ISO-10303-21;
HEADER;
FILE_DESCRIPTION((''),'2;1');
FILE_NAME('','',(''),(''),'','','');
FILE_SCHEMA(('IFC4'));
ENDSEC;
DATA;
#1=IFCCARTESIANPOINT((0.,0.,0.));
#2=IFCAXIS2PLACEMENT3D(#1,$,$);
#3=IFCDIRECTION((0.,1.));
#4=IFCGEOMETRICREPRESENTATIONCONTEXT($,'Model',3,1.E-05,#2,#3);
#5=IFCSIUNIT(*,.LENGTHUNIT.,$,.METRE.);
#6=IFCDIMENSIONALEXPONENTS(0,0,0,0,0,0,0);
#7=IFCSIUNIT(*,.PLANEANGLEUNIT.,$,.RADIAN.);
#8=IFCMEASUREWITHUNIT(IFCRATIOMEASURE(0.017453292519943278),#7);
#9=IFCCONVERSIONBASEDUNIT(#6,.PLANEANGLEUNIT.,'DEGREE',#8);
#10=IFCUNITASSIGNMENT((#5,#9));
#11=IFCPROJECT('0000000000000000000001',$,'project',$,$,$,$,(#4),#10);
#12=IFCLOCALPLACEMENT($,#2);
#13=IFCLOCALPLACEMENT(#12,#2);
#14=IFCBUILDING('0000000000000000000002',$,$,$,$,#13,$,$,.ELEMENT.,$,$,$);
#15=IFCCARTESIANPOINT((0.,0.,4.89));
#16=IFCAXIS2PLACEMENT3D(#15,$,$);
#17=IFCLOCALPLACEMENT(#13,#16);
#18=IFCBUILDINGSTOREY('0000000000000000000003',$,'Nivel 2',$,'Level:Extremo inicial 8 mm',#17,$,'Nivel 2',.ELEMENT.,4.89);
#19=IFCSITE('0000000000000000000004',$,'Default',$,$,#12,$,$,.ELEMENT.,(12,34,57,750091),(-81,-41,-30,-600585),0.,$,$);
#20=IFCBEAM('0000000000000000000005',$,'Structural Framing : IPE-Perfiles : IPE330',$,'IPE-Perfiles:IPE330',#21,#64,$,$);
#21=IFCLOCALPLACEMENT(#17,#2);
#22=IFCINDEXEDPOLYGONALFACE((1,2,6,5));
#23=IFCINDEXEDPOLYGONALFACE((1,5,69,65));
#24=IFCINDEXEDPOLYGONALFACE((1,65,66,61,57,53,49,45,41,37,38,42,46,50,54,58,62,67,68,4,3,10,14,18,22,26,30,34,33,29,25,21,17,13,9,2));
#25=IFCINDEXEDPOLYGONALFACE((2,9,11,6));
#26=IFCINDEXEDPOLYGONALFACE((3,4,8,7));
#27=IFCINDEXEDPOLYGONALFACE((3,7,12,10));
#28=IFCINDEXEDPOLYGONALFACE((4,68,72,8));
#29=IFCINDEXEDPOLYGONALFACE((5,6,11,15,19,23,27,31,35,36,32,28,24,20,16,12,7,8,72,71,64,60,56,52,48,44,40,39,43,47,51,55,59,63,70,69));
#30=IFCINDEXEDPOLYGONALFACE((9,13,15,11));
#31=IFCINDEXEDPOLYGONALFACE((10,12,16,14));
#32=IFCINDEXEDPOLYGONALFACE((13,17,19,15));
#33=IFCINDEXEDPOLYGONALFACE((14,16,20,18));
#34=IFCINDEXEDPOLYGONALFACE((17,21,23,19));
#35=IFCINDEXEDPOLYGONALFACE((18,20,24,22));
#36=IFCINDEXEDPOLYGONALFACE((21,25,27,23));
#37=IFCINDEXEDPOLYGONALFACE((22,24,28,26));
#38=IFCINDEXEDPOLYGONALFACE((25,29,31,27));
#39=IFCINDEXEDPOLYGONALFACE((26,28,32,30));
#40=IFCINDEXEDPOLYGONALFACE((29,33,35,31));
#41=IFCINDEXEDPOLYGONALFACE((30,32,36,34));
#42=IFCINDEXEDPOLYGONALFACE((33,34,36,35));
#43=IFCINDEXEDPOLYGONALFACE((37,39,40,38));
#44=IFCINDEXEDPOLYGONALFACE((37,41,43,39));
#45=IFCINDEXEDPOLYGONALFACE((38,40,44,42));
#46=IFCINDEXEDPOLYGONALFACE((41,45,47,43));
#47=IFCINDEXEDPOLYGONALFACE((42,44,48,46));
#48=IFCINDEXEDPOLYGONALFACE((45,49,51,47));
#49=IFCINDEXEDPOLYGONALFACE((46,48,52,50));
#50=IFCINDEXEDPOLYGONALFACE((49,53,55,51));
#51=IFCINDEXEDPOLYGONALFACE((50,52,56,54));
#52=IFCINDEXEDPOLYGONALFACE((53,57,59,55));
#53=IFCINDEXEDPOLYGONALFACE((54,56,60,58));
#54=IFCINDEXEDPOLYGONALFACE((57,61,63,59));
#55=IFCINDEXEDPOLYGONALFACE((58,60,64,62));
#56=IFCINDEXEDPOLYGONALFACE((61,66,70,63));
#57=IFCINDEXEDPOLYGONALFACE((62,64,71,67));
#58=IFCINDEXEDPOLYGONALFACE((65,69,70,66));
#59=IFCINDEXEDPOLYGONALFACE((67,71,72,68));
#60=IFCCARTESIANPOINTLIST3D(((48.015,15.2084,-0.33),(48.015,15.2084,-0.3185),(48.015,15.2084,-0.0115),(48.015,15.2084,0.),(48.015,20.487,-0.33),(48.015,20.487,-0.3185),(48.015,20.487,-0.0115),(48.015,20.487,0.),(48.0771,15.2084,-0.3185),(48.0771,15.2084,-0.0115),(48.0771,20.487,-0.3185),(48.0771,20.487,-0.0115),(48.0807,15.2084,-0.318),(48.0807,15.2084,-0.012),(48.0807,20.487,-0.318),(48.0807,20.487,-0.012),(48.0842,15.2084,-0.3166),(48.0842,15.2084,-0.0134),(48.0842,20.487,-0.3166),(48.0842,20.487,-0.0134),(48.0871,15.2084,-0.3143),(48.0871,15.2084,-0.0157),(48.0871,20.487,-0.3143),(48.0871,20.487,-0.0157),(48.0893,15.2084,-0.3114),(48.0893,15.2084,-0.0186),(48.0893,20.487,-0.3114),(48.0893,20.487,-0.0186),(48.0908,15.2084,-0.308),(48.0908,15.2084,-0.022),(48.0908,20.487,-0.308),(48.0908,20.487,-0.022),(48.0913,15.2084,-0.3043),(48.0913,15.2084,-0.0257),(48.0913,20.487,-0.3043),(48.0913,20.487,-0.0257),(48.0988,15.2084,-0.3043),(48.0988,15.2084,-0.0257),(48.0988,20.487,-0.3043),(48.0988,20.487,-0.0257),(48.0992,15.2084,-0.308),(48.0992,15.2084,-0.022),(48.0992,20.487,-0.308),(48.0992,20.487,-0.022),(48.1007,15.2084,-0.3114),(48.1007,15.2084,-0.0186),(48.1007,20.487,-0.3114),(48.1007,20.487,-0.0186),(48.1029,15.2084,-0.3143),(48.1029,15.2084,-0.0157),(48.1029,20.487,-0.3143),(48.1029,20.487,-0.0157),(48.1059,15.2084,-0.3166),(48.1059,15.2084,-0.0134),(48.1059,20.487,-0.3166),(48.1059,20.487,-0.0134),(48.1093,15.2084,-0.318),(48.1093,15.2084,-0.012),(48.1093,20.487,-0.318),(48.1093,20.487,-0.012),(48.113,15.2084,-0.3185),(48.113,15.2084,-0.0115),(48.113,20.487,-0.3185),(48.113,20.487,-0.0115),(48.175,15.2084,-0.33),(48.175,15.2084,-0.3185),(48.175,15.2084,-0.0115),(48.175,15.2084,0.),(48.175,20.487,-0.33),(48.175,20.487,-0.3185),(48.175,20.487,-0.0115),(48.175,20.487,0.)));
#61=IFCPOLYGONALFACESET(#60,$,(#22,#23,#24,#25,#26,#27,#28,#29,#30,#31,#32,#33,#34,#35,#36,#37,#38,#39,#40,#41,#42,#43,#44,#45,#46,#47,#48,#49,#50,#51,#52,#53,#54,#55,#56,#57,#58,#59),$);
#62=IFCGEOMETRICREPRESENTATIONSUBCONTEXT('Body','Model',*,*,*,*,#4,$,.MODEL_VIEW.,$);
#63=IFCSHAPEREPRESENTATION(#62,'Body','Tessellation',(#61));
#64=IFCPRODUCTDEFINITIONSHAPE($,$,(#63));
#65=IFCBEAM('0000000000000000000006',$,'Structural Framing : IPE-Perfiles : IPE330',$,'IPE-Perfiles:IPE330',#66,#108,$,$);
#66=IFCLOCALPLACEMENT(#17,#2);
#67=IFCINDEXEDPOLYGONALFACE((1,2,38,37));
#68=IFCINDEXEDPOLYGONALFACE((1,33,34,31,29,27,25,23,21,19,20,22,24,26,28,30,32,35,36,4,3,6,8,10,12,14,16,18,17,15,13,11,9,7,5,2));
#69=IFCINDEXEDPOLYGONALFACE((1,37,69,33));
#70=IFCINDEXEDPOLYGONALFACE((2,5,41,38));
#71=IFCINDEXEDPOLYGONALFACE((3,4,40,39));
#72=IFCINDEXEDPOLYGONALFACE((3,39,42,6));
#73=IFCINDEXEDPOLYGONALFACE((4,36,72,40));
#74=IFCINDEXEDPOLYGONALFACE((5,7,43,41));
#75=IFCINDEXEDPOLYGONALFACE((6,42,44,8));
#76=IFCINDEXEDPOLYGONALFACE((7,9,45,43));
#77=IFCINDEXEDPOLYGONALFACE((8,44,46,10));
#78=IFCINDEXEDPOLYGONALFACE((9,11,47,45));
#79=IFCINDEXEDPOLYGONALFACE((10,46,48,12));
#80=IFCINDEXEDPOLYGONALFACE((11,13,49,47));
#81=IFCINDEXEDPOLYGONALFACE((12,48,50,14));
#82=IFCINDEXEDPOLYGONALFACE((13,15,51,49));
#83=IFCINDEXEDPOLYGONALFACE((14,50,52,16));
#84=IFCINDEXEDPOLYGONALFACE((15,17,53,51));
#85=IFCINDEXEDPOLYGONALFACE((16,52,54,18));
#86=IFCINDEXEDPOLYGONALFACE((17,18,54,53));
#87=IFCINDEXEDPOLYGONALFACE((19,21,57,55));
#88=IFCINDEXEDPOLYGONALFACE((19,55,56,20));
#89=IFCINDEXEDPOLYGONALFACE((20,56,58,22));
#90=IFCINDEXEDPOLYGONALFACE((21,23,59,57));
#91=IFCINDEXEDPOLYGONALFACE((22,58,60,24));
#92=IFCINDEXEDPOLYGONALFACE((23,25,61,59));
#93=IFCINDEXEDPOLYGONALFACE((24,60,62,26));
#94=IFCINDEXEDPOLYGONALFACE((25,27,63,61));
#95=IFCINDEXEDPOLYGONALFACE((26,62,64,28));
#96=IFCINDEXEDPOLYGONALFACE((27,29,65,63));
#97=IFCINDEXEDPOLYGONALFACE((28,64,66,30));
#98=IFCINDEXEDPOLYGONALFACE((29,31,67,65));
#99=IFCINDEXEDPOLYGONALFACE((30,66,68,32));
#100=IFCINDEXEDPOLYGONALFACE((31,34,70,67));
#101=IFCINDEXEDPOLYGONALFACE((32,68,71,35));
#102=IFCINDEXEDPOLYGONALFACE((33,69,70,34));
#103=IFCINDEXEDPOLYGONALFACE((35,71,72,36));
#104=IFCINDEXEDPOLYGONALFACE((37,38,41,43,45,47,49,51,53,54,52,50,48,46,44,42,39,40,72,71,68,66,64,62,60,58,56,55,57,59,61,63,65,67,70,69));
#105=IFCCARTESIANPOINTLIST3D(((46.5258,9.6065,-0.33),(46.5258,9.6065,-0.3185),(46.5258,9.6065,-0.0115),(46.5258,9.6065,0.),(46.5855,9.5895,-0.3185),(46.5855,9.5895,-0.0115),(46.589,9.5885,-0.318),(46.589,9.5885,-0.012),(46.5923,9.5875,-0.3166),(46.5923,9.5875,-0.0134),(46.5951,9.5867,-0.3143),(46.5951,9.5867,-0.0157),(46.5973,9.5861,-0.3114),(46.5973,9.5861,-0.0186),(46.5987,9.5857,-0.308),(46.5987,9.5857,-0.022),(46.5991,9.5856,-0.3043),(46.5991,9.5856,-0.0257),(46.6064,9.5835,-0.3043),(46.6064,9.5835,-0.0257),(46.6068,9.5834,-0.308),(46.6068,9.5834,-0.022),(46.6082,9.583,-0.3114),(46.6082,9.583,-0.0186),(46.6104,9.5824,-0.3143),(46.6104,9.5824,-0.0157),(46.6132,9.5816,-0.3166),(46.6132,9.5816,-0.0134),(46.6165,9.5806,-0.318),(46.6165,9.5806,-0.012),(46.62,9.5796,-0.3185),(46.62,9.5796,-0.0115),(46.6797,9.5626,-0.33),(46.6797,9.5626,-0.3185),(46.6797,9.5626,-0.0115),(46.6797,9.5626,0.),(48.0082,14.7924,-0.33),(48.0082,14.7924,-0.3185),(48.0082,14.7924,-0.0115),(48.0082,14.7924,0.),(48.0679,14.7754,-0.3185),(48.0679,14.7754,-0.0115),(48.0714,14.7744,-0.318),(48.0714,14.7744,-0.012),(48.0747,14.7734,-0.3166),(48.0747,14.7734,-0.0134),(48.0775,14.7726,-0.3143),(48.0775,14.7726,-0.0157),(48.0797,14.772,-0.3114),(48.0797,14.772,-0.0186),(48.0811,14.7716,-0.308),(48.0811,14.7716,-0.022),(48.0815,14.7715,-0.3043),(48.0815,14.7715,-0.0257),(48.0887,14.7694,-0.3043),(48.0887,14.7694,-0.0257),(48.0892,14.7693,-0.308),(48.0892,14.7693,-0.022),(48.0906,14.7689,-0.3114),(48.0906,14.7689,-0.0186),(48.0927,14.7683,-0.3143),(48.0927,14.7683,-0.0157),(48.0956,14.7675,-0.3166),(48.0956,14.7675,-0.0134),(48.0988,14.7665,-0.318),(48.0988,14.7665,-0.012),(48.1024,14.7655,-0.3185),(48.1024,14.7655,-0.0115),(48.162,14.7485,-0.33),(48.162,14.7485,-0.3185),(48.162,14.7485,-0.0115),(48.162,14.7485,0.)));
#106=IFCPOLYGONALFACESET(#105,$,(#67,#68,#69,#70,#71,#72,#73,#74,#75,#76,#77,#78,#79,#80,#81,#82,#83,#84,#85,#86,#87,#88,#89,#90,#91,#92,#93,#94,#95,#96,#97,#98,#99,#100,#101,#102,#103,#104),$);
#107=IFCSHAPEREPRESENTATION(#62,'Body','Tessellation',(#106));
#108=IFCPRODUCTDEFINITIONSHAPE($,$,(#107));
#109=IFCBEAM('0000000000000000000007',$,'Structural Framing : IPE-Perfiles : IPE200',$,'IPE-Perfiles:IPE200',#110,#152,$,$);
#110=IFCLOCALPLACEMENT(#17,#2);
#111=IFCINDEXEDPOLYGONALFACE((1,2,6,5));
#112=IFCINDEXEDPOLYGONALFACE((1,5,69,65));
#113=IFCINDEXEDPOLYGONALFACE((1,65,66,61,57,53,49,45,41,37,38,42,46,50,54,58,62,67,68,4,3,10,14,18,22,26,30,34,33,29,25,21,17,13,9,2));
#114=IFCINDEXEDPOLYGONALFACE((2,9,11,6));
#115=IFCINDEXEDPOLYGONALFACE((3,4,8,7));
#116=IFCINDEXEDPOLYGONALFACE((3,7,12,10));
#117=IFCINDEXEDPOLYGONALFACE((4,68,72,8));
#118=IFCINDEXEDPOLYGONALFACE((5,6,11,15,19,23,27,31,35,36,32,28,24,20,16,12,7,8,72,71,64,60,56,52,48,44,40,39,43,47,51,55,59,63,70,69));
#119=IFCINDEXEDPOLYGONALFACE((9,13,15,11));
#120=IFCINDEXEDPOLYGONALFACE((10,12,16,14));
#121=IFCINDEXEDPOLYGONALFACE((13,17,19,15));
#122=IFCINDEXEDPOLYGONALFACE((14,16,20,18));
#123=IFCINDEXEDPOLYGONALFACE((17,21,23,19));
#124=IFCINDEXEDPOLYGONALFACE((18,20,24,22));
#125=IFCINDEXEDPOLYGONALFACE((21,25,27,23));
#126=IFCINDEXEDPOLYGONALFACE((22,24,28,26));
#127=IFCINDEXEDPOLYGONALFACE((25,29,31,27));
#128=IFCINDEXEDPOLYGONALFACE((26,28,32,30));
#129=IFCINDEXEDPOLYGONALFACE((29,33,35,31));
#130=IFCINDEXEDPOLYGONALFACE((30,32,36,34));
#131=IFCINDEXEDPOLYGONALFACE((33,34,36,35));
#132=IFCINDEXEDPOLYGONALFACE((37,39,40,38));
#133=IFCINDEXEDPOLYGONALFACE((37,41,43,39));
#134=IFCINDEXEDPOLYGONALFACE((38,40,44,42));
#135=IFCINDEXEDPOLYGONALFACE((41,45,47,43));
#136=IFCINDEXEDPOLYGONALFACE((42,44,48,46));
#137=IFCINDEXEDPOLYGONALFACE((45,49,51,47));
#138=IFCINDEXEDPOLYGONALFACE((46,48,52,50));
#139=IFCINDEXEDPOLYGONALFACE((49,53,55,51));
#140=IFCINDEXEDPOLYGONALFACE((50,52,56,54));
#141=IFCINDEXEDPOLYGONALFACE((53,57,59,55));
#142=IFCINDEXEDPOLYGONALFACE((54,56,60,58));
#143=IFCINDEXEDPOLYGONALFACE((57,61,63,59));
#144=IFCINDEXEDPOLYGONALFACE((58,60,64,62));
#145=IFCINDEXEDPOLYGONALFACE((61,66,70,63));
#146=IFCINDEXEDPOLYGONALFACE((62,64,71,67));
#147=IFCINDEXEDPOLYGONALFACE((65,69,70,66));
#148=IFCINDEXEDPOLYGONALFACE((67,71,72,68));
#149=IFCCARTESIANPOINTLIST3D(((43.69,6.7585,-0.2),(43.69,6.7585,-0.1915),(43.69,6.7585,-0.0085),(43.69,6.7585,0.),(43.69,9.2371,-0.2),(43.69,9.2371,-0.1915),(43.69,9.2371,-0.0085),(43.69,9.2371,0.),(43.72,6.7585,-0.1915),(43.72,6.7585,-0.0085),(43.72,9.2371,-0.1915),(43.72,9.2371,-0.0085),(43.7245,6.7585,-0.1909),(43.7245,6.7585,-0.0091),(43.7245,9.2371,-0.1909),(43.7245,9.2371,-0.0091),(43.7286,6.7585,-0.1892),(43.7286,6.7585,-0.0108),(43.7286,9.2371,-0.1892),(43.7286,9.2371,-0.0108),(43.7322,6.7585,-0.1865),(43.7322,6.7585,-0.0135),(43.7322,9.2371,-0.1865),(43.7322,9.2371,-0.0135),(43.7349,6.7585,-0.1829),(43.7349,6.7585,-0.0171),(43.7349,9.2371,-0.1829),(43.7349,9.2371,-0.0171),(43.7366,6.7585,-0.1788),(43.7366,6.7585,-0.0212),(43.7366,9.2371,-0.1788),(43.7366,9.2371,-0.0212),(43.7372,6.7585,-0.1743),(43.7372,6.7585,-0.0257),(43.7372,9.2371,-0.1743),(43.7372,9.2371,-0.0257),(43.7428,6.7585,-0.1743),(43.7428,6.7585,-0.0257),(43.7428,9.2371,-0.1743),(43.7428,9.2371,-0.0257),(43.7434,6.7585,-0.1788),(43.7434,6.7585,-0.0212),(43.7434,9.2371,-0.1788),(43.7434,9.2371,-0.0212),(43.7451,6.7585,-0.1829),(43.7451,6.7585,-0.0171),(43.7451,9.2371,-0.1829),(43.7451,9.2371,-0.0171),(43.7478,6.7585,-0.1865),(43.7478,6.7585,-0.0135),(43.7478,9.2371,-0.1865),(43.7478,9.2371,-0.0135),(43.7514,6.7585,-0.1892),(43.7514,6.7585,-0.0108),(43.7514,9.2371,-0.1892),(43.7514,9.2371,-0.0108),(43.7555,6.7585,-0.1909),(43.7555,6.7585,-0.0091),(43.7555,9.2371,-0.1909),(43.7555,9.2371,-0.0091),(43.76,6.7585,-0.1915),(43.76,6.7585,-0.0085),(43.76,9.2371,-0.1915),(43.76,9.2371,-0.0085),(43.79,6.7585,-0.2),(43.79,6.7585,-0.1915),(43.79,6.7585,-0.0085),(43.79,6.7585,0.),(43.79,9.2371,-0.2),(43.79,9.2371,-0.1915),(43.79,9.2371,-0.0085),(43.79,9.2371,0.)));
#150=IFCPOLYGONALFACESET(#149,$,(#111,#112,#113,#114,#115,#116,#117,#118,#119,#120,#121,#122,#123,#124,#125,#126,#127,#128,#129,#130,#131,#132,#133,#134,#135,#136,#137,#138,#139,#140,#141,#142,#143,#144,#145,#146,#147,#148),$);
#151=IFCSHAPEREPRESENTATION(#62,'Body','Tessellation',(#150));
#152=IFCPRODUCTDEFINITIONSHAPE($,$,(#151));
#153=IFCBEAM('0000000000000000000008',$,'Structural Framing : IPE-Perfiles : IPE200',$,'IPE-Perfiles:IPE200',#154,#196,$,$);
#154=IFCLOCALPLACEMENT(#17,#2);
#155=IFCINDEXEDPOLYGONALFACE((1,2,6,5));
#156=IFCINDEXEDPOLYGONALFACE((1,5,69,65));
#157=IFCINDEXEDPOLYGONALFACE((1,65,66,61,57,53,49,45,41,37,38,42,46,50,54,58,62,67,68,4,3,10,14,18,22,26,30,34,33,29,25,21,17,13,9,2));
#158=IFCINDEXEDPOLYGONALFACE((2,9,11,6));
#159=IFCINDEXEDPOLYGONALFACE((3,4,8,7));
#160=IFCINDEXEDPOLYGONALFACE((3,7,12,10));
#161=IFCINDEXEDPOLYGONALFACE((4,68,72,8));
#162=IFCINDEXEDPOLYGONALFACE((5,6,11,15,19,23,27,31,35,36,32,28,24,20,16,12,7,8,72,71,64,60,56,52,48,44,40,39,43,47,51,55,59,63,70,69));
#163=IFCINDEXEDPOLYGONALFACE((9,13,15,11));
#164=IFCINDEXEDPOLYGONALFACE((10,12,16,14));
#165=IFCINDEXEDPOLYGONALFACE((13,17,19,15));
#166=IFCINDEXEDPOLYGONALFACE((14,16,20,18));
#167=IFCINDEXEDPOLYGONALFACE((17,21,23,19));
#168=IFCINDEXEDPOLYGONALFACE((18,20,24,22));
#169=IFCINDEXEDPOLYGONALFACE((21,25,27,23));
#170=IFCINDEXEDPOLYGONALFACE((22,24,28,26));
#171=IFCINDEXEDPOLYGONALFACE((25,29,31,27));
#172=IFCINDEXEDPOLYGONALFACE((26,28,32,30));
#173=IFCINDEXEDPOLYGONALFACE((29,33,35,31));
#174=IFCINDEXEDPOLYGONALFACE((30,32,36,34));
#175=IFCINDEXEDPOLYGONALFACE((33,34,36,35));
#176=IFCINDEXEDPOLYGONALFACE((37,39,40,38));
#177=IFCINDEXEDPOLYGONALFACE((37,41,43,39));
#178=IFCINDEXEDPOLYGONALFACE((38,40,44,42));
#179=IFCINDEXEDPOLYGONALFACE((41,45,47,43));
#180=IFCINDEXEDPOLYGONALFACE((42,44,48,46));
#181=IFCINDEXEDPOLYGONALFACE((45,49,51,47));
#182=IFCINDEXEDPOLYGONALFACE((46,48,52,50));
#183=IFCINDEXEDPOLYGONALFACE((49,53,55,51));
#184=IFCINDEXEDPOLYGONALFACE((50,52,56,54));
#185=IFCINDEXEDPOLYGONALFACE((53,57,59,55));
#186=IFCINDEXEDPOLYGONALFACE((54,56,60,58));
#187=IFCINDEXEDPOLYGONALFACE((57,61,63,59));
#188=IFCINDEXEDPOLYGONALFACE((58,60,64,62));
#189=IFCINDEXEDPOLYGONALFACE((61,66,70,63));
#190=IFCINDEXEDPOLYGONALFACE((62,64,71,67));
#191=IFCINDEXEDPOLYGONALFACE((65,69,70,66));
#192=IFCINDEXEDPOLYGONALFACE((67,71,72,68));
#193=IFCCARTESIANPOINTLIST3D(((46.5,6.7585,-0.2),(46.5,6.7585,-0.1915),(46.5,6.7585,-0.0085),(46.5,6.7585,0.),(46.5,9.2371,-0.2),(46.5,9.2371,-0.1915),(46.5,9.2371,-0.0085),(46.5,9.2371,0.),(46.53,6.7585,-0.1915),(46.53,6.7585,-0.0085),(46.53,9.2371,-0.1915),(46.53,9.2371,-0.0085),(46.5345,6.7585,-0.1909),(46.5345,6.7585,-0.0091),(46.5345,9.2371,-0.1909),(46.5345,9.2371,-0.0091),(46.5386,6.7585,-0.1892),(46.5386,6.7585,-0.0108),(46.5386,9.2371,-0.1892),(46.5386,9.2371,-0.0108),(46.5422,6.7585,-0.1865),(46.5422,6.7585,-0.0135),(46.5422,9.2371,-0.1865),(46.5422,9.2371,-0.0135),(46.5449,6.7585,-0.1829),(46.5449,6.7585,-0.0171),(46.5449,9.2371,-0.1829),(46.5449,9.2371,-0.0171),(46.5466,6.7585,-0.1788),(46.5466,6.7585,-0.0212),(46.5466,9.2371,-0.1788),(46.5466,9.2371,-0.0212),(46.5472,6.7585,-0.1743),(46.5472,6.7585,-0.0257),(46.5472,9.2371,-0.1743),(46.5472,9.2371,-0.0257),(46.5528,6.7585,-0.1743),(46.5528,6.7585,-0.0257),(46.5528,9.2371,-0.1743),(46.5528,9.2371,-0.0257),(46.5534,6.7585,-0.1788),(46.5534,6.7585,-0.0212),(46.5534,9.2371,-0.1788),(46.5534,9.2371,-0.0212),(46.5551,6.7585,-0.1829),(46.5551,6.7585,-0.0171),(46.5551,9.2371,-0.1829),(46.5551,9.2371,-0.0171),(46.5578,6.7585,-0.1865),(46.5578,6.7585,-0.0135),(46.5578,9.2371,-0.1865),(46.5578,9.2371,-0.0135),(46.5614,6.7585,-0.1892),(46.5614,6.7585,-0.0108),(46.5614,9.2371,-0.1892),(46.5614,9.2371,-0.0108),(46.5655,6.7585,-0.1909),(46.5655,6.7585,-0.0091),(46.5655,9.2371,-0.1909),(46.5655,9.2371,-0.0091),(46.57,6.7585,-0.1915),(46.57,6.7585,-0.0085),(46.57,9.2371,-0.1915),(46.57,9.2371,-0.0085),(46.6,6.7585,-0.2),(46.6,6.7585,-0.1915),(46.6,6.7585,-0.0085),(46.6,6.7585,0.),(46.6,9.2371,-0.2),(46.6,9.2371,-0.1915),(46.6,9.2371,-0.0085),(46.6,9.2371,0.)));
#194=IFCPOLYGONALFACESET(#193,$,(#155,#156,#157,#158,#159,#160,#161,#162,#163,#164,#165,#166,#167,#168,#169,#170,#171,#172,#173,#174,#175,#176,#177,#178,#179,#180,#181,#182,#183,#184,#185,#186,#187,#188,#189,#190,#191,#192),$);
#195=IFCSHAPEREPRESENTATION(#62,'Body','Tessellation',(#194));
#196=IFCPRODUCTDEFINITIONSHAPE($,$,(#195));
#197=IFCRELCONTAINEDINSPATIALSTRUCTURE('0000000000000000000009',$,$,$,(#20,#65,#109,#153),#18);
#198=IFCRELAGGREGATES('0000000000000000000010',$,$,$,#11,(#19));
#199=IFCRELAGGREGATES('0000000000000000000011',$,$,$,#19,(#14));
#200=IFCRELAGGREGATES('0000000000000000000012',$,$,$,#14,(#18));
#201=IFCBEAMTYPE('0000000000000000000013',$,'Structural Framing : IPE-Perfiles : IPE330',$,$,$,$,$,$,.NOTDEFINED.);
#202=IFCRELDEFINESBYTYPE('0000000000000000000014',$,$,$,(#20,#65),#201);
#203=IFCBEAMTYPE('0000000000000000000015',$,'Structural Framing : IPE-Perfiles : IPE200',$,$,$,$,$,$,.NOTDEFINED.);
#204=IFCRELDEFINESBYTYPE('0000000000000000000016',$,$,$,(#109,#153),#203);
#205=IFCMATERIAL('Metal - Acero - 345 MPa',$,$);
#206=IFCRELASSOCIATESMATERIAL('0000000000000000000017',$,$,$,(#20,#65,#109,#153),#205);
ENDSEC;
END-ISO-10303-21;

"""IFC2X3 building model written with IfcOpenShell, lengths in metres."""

from ifc_helpers import new_model, entity, si_unit, converted_unit, direction, frame, frame_2d, origin, place, context, subcontext, project, spatial, i_section, extrude, material, type_object, element, save


model = new_model("IFC2X3")

# Units and contexts
model_context = context("Model", 3, precision=1e-05, world=origin(), true_north=direction((0.0, 1.0)))
body_context = subcontext(model_context, "Body", "Model", "MODEL_VIEW")
ifc_project = project(units=[si_unit("LENGTHUNIT", "METRE"), converted_unit("PLANEANGLEUNIT", "DEGREE", entity("IfcRatioMeasure", 0.017453292519943278), si_unit("PLANEANGLEUNIT", "RADIAN"), dimensions=[0, 0, 0, 0, 0, 0, 0])], contexts=[model_context])

# Site, building, storey
site_placement = place(None, origin())
site = spatial("IfcSite", under=ifc_project, at=site_placement, Name="Default", CompositionType="ELEMENT", RefLatitude=(12, 34, 57, 750091), RefLongitude=(-81, -41, -30, -600585), RefElevation=0.0)
building_placement = place(site_placement, origin())
building = spatial("IfcBuilding", under=site, at=building_placement, CompositionType="ELEMENT")
storey_placement = place(building_placement, frame((0.0, 0.0, 4.89)))
storey = spatial("IfcBuildingStorey", under=building, at=storey_placement, Name="Nivel 2", ObjectType="Level:Extremo inicial 8 mm", LongName="Nivel 2", CompositionType="ELEMENT", Elevation=4.89)

# Shared definitions
ifc_material_1 = material(Name="Metal - Acero - 345 MPa")

# Beams
beam_type_1 = type_object("IfcBeamType", Name="Structural Framing : IPE-Perfiles : IPE330", PredefinedType="NOTDEFINED")
beam_1_placement = place(storey_placement, frame((48.095, 15.195, 0.0), z_axis=(0.0, 0.0, 1.0), x_axis=(0.0, 1.0, 0.0)))
element("IfcBeam", 1, at=beam_1_placement, inside=storey, type_object=beam_type_1, material=ifc_material_1, Name="Structural Framing : IPE-Perfiles : IPE330", ObjectType="IPE-Perfiles:IPE330", context=body_context, shape_type="SweptSolid", body=[
    extrude(i_section(OverallWidth=0.16, OverallDepth=0.33, WebThickness=0.0075, FlangeThickness=0.0115, FilletRadius=0.0142, at=frame_2d((0.0, 0.0), x_axis=(0.0, 1.0))), frame((0.0135, 0.0, -0.165), z_axis=(1.0, 0.0, 0.0), x_axis=(0.0, 0.0, -1.0)), (0.0, 0.0, 1.0), 5.2786),
])
beam_2_placement = place(storey_placement, frame((46.55, 9.4, 0.0), z_axis=(0.0, 0.0, 1.0), x_axis=(0.274839, 0.96149, 0.0)))
element("IfcBeam", 2, at=beam_2_placement, inside=storey, type_object=beam_type_1, material=ifc_material_1, Name="Structural Framing : IPE-Perfiles : IPE330", ObjectType="IPE-Perfiles:IPE330", context=body_context, shape_type="SweptSolid", body=[
    extrude(i_section(OverallWidth=0.16, OverallDepth=0.33, WebThickness=0.0075, FlangeThickness=0.0115, FilletRadius=0.0142, at=frame_2d((0.0, 0.0), x_axis=(0.0, 1.0))), frame((0.1919, 0.0, -0.165), z_axis=(1.0, 0.0, 0.0), x_axis=(0.0, 0.0, -1.0)), (0.0, 0.0, 1.0), 5.3936),
])
beam_type_2 = type_object("IfcBeamType", Name="Structural Framing : IPE-Perfiles : IPE200", PredefinedType="NOTDEFINED")
beam_3_placement = place(storey_placement, frame((43.74, 6.745, 0.0), z_axis=(0.0, 0.0, 1.0), x_axis=(0.0, 1.0, 0.0)))
element("IfcBeam", 3, at=beam_3_placement, inside=storey, type_object=beam_type_2, material=ifc_material_1, Name="Structural Framing : IPE-Perfiles : IPE200", ObjectType="IPE-Perfiles:IPE200", context=body_context, shape_type="SweptSolid", body=[
    extrude(i_section(OverallWidth=0.1, OverallDepth=0.2, WebThickness=0.0056, FlangeThickness=0.0085, FilletRadius=0.0172, at=frame_2d((0.0, 0.0), x_axis=(0.0, 1.0))), frame((0.0134, 0.0, -0.1), z_axis=(1.0, 0.0, 0.0), x_axis=(0.0, 0.0, -1.0)), (0.0, 0.0, 1.0), 2.4786),
])
beam_4_placement = place(storey_placement, frame((46.55, 6.745, 0.0), z_axis=(0.0, 0.0, 1.0), x_axis=(0.0, 1.0, 0.0)))
element("IfcBeam", 4, at=beam_4_placement, inside=storey, type_object=beam_type_2, material=ifc_material_1, Name="Structural Framing : IPE-Perfiles : IPE200", ObjectType="IPE-Perfiles:IPE200", context=body_context, shape_type="SweptSolid", body=[
    extrude(i_section(OverallWidth=0.1, OverallDepth=0.2, WebThickness=0.0056, FlangeThickness=0.0085, FilletRadius=0.0172, at=frame_2d((0.0, 0.0), x_axis=(0.0, 1.0))), frame((0.0134, 0.0, -0.1), z_axis=(1.0, 0.0, 0.0), x_axis=(0.0, 0.0, -1.0)), (0.0, 0.0, 1.0), 2.4786),
])

save(model, "model.ifc")
